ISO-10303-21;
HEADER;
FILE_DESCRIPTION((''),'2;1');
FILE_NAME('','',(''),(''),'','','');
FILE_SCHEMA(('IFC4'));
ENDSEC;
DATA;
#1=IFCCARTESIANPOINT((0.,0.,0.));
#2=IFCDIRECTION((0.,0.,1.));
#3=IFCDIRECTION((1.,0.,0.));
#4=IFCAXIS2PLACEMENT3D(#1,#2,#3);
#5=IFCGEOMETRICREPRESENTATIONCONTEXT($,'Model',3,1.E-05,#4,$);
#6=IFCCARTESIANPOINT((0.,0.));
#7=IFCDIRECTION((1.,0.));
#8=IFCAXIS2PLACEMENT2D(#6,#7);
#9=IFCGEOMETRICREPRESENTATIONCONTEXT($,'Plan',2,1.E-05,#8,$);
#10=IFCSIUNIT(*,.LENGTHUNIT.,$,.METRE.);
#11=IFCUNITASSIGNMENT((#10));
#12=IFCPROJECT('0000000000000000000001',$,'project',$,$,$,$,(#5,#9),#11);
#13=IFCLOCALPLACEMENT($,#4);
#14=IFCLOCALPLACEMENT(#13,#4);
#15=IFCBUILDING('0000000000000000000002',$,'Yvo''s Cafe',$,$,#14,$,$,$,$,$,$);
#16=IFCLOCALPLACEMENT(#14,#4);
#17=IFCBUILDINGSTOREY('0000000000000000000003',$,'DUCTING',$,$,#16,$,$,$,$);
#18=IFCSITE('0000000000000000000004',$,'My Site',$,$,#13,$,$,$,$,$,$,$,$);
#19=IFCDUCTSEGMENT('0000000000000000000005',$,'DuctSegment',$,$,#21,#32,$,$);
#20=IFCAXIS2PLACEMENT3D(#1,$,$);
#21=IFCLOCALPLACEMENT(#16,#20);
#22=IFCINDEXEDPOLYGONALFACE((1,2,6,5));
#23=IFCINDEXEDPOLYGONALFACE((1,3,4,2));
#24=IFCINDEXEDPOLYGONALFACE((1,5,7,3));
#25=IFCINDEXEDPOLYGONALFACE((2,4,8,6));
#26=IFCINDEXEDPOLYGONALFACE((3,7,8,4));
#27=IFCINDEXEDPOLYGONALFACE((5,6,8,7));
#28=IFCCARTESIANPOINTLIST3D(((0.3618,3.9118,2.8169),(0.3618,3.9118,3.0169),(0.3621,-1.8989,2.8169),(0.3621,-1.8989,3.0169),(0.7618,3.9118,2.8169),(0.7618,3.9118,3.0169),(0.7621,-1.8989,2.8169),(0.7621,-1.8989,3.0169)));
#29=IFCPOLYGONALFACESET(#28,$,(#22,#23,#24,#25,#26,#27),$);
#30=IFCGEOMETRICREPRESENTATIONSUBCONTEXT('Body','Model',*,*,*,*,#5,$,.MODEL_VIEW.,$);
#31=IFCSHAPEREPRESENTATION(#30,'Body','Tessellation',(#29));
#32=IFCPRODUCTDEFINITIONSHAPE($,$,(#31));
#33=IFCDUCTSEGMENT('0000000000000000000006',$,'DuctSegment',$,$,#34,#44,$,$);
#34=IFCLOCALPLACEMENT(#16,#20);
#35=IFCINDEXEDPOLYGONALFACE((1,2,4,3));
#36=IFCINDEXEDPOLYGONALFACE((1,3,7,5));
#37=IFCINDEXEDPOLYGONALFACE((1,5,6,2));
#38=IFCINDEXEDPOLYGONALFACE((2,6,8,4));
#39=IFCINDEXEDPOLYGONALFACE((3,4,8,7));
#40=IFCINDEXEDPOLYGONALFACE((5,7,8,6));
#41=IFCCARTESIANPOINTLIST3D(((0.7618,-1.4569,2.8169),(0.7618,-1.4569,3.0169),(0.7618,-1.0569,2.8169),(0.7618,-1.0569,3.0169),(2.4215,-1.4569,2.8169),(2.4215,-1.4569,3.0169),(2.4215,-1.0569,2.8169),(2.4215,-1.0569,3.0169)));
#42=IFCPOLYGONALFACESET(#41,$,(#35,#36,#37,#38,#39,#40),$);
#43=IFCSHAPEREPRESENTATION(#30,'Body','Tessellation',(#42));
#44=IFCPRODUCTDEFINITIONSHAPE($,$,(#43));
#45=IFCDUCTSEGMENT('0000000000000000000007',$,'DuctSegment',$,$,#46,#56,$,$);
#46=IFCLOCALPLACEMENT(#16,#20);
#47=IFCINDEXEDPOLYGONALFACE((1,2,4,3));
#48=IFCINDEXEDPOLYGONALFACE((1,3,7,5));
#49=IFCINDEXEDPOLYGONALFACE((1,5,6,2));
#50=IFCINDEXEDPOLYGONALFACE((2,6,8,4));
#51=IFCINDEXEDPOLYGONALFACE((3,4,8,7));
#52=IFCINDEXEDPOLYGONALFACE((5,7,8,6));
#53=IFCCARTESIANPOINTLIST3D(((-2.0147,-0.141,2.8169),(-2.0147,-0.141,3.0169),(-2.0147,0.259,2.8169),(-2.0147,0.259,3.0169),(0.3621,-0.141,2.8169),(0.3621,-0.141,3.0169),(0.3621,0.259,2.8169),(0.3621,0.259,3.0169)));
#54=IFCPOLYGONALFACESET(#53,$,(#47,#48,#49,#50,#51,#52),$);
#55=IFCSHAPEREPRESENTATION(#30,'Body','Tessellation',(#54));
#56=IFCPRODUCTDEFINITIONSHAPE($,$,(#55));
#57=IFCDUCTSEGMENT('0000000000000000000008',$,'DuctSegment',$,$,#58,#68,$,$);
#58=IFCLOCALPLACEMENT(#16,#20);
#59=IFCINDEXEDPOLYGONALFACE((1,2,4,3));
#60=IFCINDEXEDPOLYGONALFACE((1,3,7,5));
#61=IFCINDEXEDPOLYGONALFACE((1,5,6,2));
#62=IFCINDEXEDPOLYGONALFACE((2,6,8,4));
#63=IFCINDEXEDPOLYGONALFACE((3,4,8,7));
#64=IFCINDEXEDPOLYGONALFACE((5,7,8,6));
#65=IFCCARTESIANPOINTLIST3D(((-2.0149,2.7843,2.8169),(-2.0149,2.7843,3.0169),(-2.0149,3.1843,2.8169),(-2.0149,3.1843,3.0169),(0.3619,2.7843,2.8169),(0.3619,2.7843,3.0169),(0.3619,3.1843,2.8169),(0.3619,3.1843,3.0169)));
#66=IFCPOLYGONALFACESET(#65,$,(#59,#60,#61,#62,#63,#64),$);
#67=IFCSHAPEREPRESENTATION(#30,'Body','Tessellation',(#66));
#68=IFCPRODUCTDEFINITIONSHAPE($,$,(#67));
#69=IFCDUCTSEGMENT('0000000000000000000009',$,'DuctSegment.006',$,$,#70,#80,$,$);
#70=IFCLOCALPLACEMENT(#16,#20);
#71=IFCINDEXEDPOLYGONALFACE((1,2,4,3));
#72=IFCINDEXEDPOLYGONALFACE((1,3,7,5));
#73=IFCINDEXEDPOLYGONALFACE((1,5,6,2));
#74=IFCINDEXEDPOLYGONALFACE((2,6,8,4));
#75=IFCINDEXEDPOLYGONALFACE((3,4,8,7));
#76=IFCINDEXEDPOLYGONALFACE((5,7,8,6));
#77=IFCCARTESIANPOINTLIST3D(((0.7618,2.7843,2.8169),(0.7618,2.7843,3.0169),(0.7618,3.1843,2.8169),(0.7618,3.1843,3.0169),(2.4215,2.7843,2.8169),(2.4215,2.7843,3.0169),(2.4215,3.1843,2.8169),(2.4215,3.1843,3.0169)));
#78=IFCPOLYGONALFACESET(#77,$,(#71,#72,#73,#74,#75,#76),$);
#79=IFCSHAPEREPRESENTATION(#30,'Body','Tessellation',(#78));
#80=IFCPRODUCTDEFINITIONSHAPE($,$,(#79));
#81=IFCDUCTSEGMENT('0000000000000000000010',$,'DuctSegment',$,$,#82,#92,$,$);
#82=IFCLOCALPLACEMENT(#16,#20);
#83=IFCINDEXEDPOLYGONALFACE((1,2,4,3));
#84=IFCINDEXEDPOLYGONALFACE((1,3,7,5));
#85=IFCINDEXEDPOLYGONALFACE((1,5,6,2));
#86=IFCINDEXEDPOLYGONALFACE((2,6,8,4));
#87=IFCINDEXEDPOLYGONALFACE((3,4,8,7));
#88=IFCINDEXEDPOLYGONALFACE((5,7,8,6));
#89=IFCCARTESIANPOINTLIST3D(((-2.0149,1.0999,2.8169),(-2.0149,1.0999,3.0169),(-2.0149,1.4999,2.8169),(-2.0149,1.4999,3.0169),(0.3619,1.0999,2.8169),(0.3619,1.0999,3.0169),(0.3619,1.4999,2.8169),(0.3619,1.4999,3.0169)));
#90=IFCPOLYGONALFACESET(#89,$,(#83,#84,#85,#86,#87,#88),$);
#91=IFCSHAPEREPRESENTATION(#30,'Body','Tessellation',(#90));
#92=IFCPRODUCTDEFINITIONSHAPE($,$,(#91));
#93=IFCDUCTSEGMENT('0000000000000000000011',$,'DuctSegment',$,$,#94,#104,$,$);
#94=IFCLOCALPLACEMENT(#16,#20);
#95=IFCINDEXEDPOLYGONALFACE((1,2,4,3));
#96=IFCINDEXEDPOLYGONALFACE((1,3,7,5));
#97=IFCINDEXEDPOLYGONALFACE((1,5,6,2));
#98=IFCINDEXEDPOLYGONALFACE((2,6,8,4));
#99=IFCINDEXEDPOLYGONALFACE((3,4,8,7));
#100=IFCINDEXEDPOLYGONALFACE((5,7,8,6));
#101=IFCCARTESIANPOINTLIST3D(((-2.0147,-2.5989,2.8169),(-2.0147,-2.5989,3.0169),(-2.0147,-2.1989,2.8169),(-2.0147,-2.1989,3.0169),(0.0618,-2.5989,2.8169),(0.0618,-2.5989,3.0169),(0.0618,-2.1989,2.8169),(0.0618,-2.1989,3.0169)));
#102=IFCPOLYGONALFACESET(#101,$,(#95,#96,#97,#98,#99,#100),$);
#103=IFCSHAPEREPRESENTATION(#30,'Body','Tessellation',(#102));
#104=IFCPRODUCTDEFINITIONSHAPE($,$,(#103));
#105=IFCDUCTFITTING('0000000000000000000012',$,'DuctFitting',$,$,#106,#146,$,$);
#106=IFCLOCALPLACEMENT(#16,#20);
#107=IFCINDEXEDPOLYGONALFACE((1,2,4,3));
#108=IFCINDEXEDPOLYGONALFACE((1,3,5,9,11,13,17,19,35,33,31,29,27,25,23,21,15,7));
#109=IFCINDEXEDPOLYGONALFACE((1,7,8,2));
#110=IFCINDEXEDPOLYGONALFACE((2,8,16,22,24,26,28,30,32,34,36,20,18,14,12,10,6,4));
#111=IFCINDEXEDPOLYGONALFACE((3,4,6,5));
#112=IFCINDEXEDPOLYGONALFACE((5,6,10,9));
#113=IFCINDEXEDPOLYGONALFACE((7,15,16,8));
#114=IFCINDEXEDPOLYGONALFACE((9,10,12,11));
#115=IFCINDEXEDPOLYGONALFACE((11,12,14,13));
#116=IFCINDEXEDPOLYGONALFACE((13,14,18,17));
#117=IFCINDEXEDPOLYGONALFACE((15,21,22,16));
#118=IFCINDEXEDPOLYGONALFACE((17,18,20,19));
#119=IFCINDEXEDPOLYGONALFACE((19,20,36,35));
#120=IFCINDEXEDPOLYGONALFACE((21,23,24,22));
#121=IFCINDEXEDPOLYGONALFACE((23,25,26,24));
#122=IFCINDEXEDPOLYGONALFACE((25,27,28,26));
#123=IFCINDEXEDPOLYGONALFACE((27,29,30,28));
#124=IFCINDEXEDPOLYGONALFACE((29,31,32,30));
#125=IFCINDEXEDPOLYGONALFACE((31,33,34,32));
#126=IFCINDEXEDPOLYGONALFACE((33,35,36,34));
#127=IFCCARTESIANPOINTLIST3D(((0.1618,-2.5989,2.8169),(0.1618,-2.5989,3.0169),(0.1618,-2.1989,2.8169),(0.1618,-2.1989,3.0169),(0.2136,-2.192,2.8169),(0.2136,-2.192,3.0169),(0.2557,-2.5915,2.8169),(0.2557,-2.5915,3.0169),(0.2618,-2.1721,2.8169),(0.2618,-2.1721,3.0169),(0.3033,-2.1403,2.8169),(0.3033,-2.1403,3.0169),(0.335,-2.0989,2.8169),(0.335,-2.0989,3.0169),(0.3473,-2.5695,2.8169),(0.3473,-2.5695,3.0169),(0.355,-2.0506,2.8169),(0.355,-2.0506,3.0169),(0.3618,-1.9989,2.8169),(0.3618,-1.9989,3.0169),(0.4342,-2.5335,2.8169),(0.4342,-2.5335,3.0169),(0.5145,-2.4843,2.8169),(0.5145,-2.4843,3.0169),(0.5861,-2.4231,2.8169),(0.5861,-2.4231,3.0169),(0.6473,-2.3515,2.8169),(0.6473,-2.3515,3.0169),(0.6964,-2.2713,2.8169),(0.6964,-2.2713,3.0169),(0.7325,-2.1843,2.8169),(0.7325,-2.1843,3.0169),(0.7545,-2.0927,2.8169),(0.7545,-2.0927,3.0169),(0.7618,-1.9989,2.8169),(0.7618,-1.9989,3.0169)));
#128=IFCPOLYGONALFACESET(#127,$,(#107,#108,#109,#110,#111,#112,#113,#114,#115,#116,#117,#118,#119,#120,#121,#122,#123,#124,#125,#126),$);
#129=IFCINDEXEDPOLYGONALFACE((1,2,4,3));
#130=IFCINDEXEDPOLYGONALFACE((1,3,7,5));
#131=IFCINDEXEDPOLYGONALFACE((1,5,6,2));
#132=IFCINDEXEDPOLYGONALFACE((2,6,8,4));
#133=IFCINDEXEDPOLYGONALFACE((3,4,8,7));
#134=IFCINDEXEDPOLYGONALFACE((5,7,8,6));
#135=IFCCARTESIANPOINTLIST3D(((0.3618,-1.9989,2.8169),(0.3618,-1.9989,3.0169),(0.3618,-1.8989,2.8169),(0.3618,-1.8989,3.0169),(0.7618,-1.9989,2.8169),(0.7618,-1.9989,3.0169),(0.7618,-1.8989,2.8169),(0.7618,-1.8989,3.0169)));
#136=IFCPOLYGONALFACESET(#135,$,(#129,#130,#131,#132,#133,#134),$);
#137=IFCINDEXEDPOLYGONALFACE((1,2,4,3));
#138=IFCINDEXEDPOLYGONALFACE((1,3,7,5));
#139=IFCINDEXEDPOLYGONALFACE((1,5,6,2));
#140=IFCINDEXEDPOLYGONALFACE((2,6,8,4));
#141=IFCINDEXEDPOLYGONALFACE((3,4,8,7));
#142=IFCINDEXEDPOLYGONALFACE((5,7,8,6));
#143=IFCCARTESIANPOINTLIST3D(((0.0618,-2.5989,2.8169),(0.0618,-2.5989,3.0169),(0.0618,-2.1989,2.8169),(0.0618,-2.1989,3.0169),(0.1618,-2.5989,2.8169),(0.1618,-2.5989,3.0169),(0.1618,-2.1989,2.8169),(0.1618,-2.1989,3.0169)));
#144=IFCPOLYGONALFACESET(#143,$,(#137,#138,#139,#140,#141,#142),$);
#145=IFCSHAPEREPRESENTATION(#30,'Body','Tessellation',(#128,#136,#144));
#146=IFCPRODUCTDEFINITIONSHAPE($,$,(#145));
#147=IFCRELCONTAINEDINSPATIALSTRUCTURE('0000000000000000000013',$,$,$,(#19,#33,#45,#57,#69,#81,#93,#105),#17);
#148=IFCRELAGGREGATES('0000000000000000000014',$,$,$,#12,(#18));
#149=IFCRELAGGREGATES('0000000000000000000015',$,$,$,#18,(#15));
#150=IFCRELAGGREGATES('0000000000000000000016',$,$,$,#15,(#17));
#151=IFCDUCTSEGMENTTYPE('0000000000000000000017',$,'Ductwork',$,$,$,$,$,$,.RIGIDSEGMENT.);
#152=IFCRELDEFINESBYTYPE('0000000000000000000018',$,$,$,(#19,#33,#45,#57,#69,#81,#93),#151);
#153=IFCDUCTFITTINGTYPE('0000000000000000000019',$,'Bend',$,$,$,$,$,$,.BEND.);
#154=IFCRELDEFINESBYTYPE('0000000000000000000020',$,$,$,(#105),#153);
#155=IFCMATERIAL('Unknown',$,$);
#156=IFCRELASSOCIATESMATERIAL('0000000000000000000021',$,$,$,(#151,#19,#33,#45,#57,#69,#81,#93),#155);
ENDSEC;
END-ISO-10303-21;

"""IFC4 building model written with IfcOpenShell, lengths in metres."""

from ifc_helpers import new_model, si_unit, frame, origin_with_axes, origin_2d_with_axis, place, context, subcontext, project, spatial, line, arc, indexed_curve, rectangle, outline, extrude, source, transform, mapped, material, material_profile, profile_set, profile_usage, type_object, type_shapes, element, save


model = new_model("IFC4")

# Units and contexts
model_context = context("Model", 3, precision=1e-05, world=origin_with_axes())
plan_context = context("Plan", 2, precision=1e-05, world=origin_2d_with_axis())
body_context = subcontext(model_context, "Body", "Model", "MODEL_VIEW")
ifc_project = project(units=[si_unit("LENGTHUNIT", "METRE")], contexts=[model_context, plan_context])

# Site, building, storey
site_placement = place(None, origin_with_axes())
site = spatial("IfcSite", under=ifc_project, at=site_placement, Name="My Site")
building_placement = place(site_placement, origin_with_axes())
building = spatial("IfcBuilding", under=site, at=building_placement, Name="Yvo's Cafe")
storey_placement = place(building_placement, origin_with_axes())
storey = spatial("IfcBuildingStorey", under=building, at=storey_placement, Name="DUCTING")

# Duct segments
ifc_material = material(Name="Unknown")
ifc_material_profile = material_profile(ifc_material, rectangle(XDim=0.4, YDim=0.2))
ifc_profile_set = profile_set([ifc_material_profile])
ifc_profile_usage_1 = profile_usage(ifc_profile_set, cardinal=5)
duct_segment_type = type_object("IfcDuctSegmentType", Name="Ductwork", PredefinedType="RIGIDSEGMENT", material=ifc_profile_set)
duct_segment_1_placement = place(storey_placement, frame((0.5618, 3.9118, 2.9169), z_axis=(0.000039, -1.0, 0.0), x_axis=(1.0, 0.000039, 0.0)))
element("IfcDuctSegment", 1, at=duct_segment_1_placement, inside=storey, type_object=duct_segment_type, material=ifc_profile_usage_1, Name="DuctSegment", context=body_context, shape_type="SweptSolid", body=[
    extrude(rectangle(XDim=0.4, YDim=0.2), origin_with_axes(), (0.0, 0.0, 1.0), 5.8106),
])
ifc_profile_usage_2 = profile_usage(ifc_profile_set, cardinal=5)
duct_segment_2_placement = place(storey_placement, frame((0.7618, -1.2569, 2.9169), z_axis=(1.0, 0.0, 0.0), x_axis=(0.0, 1.0, 0.0)))
element("IfcDuctSegment", 2, at=duct_segment_2_placement, inside=storey, type_object=duct_segment_type, material=ifc_profile_usage_2, Name="DuctSegment", context=body_context, shape_type="SweptSolid", body=[
    extrude(rectangle(XDim=0.4, YDim=0.2), origin_with_axes(), (0.0, 0.0, 1.0), 1.6597),
])
ifc_profile_usage_3 = profile_usage(ifc_profile_set, cardinal=5)
duct_segment_3_placement = place(storey_placement, frame((0.3621, 0.059, 2.9169), z_axis=(-1.0, 0.0, 0.0), x_axis=(0.0, -1.0, 0.0)))
element("IfcDuctSegment", 3, at=duct_segment_3_placement, inside=storey, type_object=duct_segment_type, material=ifc_profile_usage_3, Name="DuctSegment", context=body_context, shape_type="SweptSolid", body=[
    extrude(rectangle(XDim=0.4, YDim=0.2), origin_with_axes(), (0.0, 0.0, 1.0), 2.3768),
])
ifc_profile_usage_4 = profile_usage(ifc_profile_set, cardinal=5)
duct_segment_4_placement = place(storey_placement, frame((0.3619, 2.9843, 2.9169), z_axis=(-1.0, 0.0, 0.0), x_axis=(0.0, -1.0, 0.0)))
element("IfcDuctSegment", 4, at=duct_segment_4_placement, inside=storey, type_object=duct_segment_type, material=ifc_profile_usage_4, Name="DuctSegment", context=body_context, shape_type="SweptSolid", body=[
    extrude(rectangle(XDim=0.4, YDim=0.2), origin_with_axes(), (0.0, 0.0, 1.0), 2.3768),
])
ifc_profile_usage_5 = profile_usage(ifc_profile_set, cardinal=5)
duct_segment_5_placement = place(storey_placement, frame((0.7618, 2.9843, 2.9169), z_axis=(1.0, 0.0, 0.0), x_axis=(0.0, 1.0, 0.0)))
element("IfcDuctSegment", 5, at=duct_segment_5_placement, inside=storey, type_object=duct_segment_type, material=ifc_profile_usage_5, Name="DuctSegment.006", context=body_context, shape_type="SweptSolid", body=[
    extrude(rectangle(XDim=0.4, YDim=0.2), origin_with_axes(), (0.0, 0.0, 1.0), 1.6597),
])
ifc_profile_usage_6 = profile_usage(ifc_profile_set, cardinal=5)
duct_segment_6_placement = place(storey_placement, frame((0.3619, 1.2999, 2.9169), z_axis=(-1.0, 0.0, 0.0), x_axis=(0.0, -1.0, 0.0)))
element("IfcDuctSegment", 6, at=duct_segment_6_placement, inside=storey, type_object=duct_segment_type, material=ifc_profile_usage_6, Name="DuctSegment", context=body_context, shape_type="SweptSolid", body=[
    extrude(rectangle(XDim=0.4, YDim=0.2), origin_with_axes(), (0.0, 0.0, 1.0), 2.3768),
])
ifc_profile_usage_7 = profile_usage(ifc_profile_set, cardinal=5)
duct_segment_7_placement = place(storey_placement, frame((0.0618, -2.3989, 2.9169), z_axis=(-1.0, 0.0, 0.0), x_axis=(0.0, -1.0, 0.0)))
element("IfcDuctSegment", 7, at=duct_segment_7_placement, inside=storey, type_object=duct_segment_type, material=ifc_profile_usage_7, Name="DuctSegment", context=body_context, shape_type="SweptSolid", body=[
    extrude(rectangle(XDim=0.4, YDim=0.2), origin_with_axes(), (0.0, 0.0, 1.0), 2.0765),
])

# Duct fitting
duct_fitting_type = type_object("IfcDuctFittingType", Name="Bend", PredefinedType="BEND")
shared_shape = source(origin_with_axes(), body_context, "Body", "SweptSolid", [
    extrude(outline(indexed_curve([(-0.2, 0.0), (-0.2586, 0.1414), (-0.4, 0.2), (-0.4, 0.6), (0.0243, 0.4243), (0.2, 0.0)], segments=[arc(1, 2, 3), line(3, 4), arc(4, 5, 6), line(6, 1)])), frame((0.0, -0.1, 0.1), z_axis=(0.0, -1.0, 0.0), x_axis=(1.0, 0.0, 0.0)), (0.0, 0.0, -1.0), 0.2),
    extrude(rectangle(XDim=0.4, YDim=0.2), origin_with_axes(), (0.0, 0.0, 1.0), 0.1),
    extrude(rectangle(XDim=0.4, YDim=0.2), frame((-0.4, 0.0, 0.5), z_axis=(-1.0, 0.0, 0.0), x_axis=(0.0, 0.0, -1.0)), (0.0, 0.0, 1.0), 0.1),
])
type_shapes(duct_fitting_type, [shared_shape])
duct_fitting_placement = place(storey_placement, frame((0.5618, -1.8989, 2.9169), z_axis=(0.0, -1.0, 0.0), x_axis=(1.0, 0.0, 0.0)))
element("IfcDuctFitting", 8, at=duct_fitting_placement, inside=storey, type_object=duct_fitting_type, Name="DuctFitting", context=body_context, shape_type="MappedRepresentation", body=[
    mapped(shared_shape, transform((0.0, 0.0, 0.0), x_axis=(1.0, 0.0, 0.0), y_axis=(0.0, 1.0, 0.0), z_axis=(0.0, 0.0, 1.0), scale=1.0)),
])

save(model, "model.ifc")
